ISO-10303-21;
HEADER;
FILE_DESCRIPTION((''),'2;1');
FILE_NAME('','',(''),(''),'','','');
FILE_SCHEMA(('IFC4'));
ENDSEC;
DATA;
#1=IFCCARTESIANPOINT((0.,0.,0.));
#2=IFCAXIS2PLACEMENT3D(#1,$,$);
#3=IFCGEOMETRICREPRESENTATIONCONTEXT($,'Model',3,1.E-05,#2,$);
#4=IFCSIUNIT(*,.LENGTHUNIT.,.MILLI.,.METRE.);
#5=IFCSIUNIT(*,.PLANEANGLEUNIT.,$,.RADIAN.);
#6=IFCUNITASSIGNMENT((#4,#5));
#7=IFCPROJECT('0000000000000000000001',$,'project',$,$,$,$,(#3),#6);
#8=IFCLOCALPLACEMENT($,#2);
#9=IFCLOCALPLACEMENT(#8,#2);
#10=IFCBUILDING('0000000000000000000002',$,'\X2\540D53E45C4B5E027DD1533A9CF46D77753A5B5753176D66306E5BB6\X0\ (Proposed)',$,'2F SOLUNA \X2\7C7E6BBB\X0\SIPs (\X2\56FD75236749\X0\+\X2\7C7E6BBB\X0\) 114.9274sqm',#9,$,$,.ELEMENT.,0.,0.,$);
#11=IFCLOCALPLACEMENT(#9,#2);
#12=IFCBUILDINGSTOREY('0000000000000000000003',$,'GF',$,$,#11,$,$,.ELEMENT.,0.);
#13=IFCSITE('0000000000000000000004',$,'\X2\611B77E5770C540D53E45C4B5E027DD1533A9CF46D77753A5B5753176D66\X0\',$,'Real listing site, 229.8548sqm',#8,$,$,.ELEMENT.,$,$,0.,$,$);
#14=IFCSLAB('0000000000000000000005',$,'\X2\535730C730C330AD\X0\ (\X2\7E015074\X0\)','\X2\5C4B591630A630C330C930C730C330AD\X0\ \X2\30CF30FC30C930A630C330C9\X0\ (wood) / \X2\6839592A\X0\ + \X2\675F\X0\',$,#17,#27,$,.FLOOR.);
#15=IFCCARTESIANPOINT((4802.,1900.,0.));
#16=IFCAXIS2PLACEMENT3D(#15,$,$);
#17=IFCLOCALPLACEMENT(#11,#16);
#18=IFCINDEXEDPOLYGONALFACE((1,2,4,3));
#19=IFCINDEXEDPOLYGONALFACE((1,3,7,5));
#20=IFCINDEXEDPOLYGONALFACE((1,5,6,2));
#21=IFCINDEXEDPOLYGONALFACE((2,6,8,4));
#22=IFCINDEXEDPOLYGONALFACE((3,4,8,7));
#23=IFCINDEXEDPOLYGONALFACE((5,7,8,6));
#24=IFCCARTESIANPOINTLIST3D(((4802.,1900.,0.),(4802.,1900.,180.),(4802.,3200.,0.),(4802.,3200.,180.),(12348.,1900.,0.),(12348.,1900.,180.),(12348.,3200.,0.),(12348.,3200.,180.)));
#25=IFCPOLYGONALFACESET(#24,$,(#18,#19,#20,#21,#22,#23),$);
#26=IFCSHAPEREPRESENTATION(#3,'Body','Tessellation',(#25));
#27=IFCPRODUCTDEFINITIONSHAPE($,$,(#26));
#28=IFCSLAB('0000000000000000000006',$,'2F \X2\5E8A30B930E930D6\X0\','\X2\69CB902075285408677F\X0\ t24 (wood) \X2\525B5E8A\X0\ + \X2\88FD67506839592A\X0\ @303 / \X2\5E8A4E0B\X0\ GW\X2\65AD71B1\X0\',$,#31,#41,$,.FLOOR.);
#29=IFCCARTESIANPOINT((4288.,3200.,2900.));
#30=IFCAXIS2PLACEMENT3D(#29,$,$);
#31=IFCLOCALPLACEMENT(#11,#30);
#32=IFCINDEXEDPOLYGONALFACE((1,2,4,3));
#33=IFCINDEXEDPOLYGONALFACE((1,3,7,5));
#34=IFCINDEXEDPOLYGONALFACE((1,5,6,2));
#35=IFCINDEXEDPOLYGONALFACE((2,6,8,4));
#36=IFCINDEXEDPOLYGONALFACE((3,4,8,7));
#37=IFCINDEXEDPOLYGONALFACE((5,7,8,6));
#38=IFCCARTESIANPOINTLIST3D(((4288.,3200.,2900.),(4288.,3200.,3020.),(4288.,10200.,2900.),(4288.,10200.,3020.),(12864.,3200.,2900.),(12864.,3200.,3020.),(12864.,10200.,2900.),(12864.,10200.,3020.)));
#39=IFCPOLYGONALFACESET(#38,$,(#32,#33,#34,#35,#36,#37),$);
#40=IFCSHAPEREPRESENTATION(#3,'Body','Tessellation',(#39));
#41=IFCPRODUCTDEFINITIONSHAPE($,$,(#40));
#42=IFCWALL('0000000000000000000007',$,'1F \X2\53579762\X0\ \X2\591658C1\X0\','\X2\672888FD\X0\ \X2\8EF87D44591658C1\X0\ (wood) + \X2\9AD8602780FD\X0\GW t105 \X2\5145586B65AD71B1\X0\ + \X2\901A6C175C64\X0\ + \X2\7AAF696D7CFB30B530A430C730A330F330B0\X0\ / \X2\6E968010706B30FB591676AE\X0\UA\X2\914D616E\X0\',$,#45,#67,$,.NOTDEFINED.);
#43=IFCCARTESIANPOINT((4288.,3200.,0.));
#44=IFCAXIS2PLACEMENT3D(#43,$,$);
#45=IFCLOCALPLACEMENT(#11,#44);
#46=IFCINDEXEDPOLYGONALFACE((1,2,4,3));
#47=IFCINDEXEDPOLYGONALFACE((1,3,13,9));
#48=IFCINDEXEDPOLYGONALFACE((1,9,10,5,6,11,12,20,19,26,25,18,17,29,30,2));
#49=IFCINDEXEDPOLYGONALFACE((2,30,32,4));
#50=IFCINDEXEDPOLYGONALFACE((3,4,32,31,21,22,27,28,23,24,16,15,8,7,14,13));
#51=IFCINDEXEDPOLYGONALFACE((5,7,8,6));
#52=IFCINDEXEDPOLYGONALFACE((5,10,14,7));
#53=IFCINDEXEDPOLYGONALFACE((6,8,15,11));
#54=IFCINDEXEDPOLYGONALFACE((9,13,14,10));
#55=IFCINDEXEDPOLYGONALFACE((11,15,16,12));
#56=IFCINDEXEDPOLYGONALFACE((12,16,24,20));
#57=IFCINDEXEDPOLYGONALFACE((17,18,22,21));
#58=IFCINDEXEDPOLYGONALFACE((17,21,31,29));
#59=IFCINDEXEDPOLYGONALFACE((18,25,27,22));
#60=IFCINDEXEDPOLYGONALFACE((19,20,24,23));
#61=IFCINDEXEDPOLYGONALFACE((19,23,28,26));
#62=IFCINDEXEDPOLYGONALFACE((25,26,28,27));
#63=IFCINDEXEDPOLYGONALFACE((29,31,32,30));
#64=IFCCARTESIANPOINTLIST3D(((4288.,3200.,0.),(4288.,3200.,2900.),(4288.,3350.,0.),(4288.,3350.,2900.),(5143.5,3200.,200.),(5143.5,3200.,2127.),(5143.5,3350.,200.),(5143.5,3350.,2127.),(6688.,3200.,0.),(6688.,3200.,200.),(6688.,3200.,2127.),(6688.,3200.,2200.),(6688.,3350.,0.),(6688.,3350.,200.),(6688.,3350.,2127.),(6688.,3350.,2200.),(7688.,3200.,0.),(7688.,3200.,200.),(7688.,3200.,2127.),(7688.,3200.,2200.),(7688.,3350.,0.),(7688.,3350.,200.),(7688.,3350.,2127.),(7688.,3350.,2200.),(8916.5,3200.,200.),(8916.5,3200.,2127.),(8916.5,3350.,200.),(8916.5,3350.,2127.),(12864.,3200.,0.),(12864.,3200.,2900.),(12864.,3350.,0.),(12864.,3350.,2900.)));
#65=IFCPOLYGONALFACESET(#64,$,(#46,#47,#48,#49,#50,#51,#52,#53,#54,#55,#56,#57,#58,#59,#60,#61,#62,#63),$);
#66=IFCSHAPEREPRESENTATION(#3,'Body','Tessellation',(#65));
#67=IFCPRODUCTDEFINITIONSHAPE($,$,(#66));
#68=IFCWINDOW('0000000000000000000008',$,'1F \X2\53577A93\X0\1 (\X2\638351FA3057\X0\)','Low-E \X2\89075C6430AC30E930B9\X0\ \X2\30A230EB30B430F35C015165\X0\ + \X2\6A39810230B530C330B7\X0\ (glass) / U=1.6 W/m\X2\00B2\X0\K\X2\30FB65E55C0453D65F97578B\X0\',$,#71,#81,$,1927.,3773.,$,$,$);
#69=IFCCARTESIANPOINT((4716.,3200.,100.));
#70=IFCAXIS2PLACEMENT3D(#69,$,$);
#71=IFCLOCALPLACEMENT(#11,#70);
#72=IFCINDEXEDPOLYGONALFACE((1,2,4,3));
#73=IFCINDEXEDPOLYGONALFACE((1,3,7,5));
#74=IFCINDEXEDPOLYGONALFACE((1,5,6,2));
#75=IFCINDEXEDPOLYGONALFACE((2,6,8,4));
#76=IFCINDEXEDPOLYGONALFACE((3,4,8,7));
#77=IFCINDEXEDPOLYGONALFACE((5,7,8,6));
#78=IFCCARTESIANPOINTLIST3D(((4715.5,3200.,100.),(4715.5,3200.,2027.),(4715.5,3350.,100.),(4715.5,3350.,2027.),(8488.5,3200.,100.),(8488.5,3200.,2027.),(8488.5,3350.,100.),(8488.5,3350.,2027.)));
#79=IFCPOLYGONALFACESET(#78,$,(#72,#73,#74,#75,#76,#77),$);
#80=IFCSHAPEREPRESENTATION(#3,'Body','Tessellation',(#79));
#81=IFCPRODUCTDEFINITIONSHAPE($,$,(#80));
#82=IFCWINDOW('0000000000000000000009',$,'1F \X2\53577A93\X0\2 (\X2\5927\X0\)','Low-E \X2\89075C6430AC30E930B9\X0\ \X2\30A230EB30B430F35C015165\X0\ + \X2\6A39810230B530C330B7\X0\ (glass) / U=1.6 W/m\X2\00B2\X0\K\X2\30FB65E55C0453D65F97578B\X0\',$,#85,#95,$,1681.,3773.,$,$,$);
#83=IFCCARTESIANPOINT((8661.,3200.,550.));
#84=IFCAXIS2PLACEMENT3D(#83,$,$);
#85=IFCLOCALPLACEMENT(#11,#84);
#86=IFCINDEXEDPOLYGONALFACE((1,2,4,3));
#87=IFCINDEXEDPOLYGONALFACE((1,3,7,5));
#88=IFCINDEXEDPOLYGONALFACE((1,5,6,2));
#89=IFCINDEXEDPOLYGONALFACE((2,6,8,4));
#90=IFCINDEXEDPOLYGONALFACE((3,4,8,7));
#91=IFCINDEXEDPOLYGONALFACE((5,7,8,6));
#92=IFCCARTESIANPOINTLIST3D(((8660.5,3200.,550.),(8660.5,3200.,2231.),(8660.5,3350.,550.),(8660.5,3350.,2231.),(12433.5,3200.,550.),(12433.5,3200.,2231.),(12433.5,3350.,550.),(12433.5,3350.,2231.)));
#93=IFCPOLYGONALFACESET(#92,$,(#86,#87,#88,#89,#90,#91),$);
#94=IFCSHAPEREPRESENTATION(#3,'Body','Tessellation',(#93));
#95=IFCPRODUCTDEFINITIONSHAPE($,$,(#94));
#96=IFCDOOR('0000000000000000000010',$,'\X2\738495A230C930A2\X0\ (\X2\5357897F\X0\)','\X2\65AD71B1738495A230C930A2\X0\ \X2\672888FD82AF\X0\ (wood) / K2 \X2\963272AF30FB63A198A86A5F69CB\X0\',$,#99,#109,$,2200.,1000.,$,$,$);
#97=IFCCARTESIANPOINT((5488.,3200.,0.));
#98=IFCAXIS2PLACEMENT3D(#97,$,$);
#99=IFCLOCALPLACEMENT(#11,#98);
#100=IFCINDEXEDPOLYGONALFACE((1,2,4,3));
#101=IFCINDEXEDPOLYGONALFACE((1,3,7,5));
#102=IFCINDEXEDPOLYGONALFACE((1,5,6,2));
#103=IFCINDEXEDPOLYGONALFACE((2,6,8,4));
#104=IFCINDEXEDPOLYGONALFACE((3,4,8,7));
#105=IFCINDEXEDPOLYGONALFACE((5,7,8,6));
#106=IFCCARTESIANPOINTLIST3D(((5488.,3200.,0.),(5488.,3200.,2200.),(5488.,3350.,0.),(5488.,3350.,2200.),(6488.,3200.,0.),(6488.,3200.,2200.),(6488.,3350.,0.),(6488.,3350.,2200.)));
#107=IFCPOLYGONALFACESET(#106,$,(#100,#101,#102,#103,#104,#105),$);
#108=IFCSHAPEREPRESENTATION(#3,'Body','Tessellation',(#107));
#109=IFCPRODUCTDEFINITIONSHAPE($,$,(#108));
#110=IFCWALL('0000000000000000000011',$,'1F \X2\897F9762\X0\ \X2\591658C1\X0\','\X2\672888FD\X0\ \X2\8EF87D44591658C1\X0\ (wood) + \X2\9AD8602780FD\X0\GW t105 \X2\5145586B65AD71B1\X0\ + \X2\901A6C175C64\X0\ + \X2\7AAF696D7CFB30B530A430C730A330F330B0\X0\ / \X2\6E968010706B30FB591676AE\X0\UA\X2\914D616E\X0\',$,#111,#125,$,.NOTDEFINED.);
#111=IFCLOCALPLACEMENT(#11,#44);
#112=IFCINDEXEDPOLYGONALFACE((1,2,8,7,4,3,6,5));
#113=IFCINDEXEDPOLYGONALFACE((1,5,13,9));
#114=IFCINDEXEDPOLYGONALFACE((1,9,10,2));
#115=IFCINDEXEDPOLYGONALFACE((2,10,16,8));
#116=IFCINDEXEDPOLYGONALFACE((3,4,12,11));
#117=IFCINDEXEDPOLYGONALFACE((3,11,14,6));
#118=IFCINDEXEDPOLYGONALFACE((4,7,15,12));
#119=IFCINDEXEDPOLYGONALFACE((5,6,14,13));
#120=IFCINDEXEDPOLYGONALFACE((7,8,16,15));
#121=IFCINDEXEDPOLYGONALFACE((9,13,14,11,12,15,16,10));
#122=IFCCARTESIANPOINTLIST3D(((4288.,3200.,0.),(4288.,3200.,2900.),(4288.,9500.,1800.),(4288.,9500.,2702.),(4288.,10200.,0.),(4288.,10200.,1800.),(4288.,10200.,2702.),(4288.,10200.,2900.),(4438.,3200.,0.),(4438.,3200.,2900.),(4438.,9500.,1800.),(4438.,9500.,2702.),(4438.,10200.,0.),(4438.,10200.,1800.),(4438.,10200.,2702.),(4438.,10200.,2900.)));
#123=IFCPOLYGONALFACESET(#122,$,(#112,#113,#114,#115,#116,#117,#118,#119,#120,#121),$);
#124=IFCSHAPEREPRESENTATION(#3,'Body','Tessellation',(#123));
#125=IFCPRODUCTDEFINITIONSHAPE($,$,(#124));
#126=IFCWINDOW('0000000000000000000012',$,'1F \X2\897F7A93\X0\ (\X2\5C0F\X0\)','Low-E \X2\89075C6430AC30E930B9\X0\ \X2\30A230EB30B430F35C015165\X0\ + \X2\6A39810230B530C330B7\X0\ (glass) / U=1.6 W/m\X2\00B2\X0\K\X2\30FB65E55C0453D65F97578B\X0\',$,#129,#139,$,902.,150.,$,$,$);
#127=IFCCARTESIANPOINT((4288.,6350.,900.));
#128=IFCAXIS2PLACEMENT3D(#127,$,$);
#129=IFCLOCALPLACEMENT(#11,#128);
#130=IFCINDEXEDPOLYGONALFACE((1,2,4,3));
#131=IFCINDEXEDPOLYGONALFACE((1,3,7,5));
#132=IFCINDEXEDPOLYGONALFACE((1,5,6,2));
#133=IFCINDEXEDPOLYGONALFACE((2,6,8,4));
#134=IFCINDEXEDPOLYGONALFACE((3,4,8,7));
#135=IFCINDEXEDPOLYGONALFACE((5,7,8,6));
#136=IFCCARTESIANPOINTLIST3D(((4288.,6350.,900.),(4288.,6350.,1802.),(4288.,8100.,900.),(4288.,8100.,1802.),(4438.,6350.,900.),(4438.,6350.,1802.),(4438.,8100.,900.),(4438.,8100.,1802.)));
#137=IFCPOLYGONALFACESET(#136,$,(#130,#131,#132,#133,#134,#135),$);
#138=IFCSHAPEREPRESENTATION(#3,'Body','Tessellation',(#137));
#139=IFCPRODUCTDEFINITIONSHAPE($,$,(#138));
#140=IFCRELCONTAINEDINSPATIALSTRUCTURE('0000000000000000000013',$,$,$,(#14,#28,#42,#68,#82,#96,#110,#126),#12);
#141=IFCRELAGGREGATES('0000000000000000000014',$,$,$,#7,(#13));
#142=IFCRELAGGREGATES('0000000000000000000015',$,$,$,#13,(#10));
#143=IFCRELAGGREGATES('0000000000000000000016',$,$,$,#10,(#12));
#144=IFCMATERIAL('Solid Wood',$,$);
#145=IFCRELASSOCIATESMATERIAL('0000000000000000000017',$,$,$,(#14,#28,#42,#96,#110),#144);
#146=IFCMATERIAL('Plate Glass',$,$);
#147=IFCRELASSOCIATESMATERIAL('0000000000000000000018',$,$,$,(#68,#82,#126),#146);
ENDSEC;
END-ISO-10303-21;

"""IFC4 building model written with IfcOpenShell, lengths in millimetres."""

from ifc_helpers import new_model, si_unit, frame, frame_2d, origin, place, context, project, spatial, rectangle, extrude, material, element, fill, save


model = new_model("IFC4")

# Units and contexts
model_context = context("Model", 3, precision=1e-05, world=origin())
ifc_project = project(units=[si_unit("LENGTHUNIT", "METRE", prefix="MILLI"), si_unit("PLANEANGLEUNIT", "RADIAN")], contexts=[model_context])

# Site, building, storey
site_placement = place(None, origin())
site = spatial("IfcSite", under=ifc_project, at=site_placement, Name="愛知県名古屋市緑区鳴海町字北浦", ObjectType="Real listing site, 229.8548sqm", CompositionType="ELEMENT", RefElevation=0.0)
building_placement = place(site_placement, origin())
building = spatial("IfcBuilding", under=site, at=building_placement, Name="名古屋市緑区鳴海町字北浦の家 (Proposed)", ObjectType="2F SOLUNA 籾殻SIPs (国産杉+籾殻) 114.9274sqm", CompositionType="ELEMENT", ElevationOfRefHeight=0.0, ElevationOfTerrain=0.0)
storey_placement = place(building_placement, origin())
storey = spatial("IfcBuildingStorey", under=building, at=storey_placement, Name="GF", CompositionType="ELEMENT", Elevation=0.0)

# Slabs
ifc_material_1 = material(Name="Solid Wood")
slab_1_placement = place(storey_placement, frame((4802.0, 1900.0, 0.0)))
element("IfcSlab", 1, at=slab_1_placement, inside=storey, material=ifc_material_1, Name="南デッキ (縁側)", Description="屋外ウッドデッキ ハードウッド (wood) / 根太 + 束", PredefinedType="FLOOR", context=model_context, shape_type="SweptSolid", body=[
    extrude(rectangle(XDim=7546.0, YDim=1300.0, at=frame_2d((3773.0, 650.0))), frame((4802.0, 1900.0, 0.0)), (0.0, 0.0, 1.0), 180.0),
])
slab_2_placement = place(storey_placement, frame((4288.0, 3200.0, 2900.0)))
element("IfcSlab", 2, at=slab_2_placement, inside=storey, material=ifc_material_1, Name="2F 床スラブ", Description="構造用合板 t24 (wood) 剛床 + 製材根太 @303 / 床下 GW断熱", PredefinedType="FLOOR", context=model_context, shape_type="SweptSolid", body=[
    extrude(rectangle(XDim=8576.0, YDim=7000.0, at=frame_2d((4288.0, 3500.0))), frame((4288.0, 3200.0, 2900.0)), (0.0, 0.0, 1.0), 120.0),
])

# Wall, openings, windows, door
wall_1_placement = place(storey_placement, frame((4288.0, 3200.0, 0.0)))
wall_1 = element("IfcWall", 3, at=wall_1_placement, inside=storey, material=ifc_material_1, Name="1F 南面 外壁", Description="木製 軸組外壁 (wood) + 高性能GW t105 充填断熱 + 通気層 + 窯業系サイディング / 準耐火・外皮UA配慮", PredefinedType="NOTDEFINED", context=model_context, shape_type="SweptSolid", body=[
    extrude(rectangle(XDim=8576.0, YDim=150.0, at=frame_2d((4288.0, 75.0))), frame((4288.0, 3200.0, 0.0)), (0.0, 0.0, 1.0), 2900.0),
])
opening_1_placement = place(storey_placement, frame((4716.0, 3200.0, 100.0)))
opening_1 = element("IfcOpeningElement", 4, at=opening_1_placement, cuts=wall_1, PredefinedType="NOTDEFINED", context=model_context, shape_type="SweptSolid", body=[
    extrude(rectangle(XDim=3773.0, YDim=150.0, at=frame_2d((1886.0, 75.0))), frame((4716.0, 3200.0, 100.0)), (0.0, 0.0, 1.0), 1927.0),
])
opening_2_placement = place(storey_placement, frame((8661.0, 3200.0, 550.0)))
opening_2 = element("IfcOpeningElement", 5, at=opening_2_placement, cuts=wall_1, PredefinedType="NOTDEFINED", context=model_context, shape_type="SweptSolid", body=[
    extrude(rectangle(XDim=3773.0, YDim=150.0, at=frame_2d((1886.0, 75.0))), frame((8661.0, 3200.0, 550.0)), (0.0, 0.0, 1.0), 1681.0),
])
opening_3_placement = place(storey_placement, frame((5488.0, 3200.0, 0.0)))
opening_3 = element("IfcOpeningElement", 6, at=opening_3_placement, cuts=wall_1, PredefinedType="NOTDEFINED", context=model_context, shape_type="SweptSolid", body=[
    extrude(rectangle(XDim=1000.0, YDim=150.0, at=frame_2d((500.0, 75.0))), frame((5488.0, 3200.0, 0.0)), (0.0, 0.0, 1.0), 2200.0),
])
ifc_material_2 = material(Name="Plate Glass")
window_1_placement = place(storey_placement, frame((4716.0, 3200.0, 100.0)))
window_1 = element("IfcWindow", 7, at=window_1_placement, inside=storey, material=ifc_material_2, Name="1F 南窓1 (掃出し)", Description="Low-E 複層ガラス アルゴン封入 + 樹脂サッシ (glass) / U=1.6 W/m²K・日射取得型", OverallHeight=1927.0, OverallWidth=3773.0, context=model_context, shape_type="SweptSolid", body=[
    extrude(rectangle(XDim=3773.0, YDim=150.0, at=frame_2d((1886.0, 75.0))), frame((4716.0, 3200.0, 100.0)), (0.0, 0.0, 1.0), 1927.0),
])
fill(opening_1, window_1)
window_2_placement = place(storey_placement, frame((8661.0, 3200.0, 550.0)))
window_2 = element("IfcWindow", 8, at=window_2_placement, inside=storey, material=ifc_material_2, Name="1F 南窓2 (大)", Description="Low-E 複層ガラス アルゴン封入 + 樹脂サッシ (glass) / U=1.6 W/m²K・日射取得型", OverallHeight=1681.0, OverallWidth=3773.0, context=model_context, shape_type="SweptSolid", body=[
    extrude(rectangle(XDim=3773.0, YDim=150.0, at=frame_2d((1886.0, 75.0))), frame((8661.0, 3200.0, 550.0)), (0.0, 0.0, 1.0), 1681.0),
])
fill(opening_2, window_2)
door_placement = place(storey_placement, frame((5488.0, 3200.0, 0.0)))
door = element("IfcDoor", 9, at=door_placement, inside=storey, material=ifc_material_1, Name="玄関ドア (南西)", Description="断熱玄関ドア 木製芯 (wood) / K2 防犯・採風機構", OverallHeight=2200.0, OverallWidth=1000.0, context=model_context, shape_type="SweptSolid", body=[
    extrude(rectangle(XDim=1000.0, YDim=150.0, at=frame_2d((500.0, 75.0))), frame((5488.0, 3200.0, 0.0)), (0.0, 0.0, 1.0), 2200.0),
])
fill(opening_3, door)

# Wall, opening, window
wall_2_placement = place(storey_placement, frame((4288.0, 3200.0, 0.0)))
wall_2 = element("IfcWall", 10, at=wall_2_placement, inside=storey, material=ifc_material_1, Name="1F 西面 外壁", Description="木製 軸組外壁 (wood) + 高性能GW t105 充填断熱 + 通気層 + 窯業系サイディング / 準耐火・外皮UA配慮", PredefinedType="NOTDEFINED", context=model_context, shape_type="SweptSolid", body=[
    extrude(rectangle(XDim=150.0, YDim=7000.0, at=frame_2d((75.0, 3500.0))), frame((4288.0, 3200.0, 0.0)), (0.0, 0.0, 1.0), 2900.0),
])
opening_4_placement = place(storey_placement, frame((4288.0, 6350.0, 900.0)))
opening_4 = element("IfcOpeningElement", 11, at=opening_4_placement, cuts=wall_2, PredefinedType="NOTDEFINED", context=model_context, shape_type="SweptSolid", body=[
    extrude(rectangle(XDim=150.0, YDim=1750.0, at=frame_2d((75.0, 875.0))), frame((4288.0, 6350.0, 900.0)), (0.0, 0.0, 1.0), 902.0),
])
window_3_placement = place(storey_placement, frame((4288.0, 6350.0, 900.0)))
window_3 = element("IfcWindow", 12, at=window_3_placement, inside=storey, material=ifc_material_2, Name="1F 西窓 (小)", Description="Low-E 複層ガラス アルゴン封入 + 樹脂サッシ (glass) / U=1.6 W/m²K・日射取得型", OverallHeight=902.0, OverallWidth=150.0, context=model_context, shape_type="SweptSolid", body=[
    extrude(rectangle(XDim=150.0, YDim=1750.0, at=frame_2d((75.0, 875.0))), frame((4288.0, 6350.0, 900.0)), (0.0, 0.0, 1.0), 902.0),
])
fill(opening_4, window_3)

save(model, "model.ifc")
